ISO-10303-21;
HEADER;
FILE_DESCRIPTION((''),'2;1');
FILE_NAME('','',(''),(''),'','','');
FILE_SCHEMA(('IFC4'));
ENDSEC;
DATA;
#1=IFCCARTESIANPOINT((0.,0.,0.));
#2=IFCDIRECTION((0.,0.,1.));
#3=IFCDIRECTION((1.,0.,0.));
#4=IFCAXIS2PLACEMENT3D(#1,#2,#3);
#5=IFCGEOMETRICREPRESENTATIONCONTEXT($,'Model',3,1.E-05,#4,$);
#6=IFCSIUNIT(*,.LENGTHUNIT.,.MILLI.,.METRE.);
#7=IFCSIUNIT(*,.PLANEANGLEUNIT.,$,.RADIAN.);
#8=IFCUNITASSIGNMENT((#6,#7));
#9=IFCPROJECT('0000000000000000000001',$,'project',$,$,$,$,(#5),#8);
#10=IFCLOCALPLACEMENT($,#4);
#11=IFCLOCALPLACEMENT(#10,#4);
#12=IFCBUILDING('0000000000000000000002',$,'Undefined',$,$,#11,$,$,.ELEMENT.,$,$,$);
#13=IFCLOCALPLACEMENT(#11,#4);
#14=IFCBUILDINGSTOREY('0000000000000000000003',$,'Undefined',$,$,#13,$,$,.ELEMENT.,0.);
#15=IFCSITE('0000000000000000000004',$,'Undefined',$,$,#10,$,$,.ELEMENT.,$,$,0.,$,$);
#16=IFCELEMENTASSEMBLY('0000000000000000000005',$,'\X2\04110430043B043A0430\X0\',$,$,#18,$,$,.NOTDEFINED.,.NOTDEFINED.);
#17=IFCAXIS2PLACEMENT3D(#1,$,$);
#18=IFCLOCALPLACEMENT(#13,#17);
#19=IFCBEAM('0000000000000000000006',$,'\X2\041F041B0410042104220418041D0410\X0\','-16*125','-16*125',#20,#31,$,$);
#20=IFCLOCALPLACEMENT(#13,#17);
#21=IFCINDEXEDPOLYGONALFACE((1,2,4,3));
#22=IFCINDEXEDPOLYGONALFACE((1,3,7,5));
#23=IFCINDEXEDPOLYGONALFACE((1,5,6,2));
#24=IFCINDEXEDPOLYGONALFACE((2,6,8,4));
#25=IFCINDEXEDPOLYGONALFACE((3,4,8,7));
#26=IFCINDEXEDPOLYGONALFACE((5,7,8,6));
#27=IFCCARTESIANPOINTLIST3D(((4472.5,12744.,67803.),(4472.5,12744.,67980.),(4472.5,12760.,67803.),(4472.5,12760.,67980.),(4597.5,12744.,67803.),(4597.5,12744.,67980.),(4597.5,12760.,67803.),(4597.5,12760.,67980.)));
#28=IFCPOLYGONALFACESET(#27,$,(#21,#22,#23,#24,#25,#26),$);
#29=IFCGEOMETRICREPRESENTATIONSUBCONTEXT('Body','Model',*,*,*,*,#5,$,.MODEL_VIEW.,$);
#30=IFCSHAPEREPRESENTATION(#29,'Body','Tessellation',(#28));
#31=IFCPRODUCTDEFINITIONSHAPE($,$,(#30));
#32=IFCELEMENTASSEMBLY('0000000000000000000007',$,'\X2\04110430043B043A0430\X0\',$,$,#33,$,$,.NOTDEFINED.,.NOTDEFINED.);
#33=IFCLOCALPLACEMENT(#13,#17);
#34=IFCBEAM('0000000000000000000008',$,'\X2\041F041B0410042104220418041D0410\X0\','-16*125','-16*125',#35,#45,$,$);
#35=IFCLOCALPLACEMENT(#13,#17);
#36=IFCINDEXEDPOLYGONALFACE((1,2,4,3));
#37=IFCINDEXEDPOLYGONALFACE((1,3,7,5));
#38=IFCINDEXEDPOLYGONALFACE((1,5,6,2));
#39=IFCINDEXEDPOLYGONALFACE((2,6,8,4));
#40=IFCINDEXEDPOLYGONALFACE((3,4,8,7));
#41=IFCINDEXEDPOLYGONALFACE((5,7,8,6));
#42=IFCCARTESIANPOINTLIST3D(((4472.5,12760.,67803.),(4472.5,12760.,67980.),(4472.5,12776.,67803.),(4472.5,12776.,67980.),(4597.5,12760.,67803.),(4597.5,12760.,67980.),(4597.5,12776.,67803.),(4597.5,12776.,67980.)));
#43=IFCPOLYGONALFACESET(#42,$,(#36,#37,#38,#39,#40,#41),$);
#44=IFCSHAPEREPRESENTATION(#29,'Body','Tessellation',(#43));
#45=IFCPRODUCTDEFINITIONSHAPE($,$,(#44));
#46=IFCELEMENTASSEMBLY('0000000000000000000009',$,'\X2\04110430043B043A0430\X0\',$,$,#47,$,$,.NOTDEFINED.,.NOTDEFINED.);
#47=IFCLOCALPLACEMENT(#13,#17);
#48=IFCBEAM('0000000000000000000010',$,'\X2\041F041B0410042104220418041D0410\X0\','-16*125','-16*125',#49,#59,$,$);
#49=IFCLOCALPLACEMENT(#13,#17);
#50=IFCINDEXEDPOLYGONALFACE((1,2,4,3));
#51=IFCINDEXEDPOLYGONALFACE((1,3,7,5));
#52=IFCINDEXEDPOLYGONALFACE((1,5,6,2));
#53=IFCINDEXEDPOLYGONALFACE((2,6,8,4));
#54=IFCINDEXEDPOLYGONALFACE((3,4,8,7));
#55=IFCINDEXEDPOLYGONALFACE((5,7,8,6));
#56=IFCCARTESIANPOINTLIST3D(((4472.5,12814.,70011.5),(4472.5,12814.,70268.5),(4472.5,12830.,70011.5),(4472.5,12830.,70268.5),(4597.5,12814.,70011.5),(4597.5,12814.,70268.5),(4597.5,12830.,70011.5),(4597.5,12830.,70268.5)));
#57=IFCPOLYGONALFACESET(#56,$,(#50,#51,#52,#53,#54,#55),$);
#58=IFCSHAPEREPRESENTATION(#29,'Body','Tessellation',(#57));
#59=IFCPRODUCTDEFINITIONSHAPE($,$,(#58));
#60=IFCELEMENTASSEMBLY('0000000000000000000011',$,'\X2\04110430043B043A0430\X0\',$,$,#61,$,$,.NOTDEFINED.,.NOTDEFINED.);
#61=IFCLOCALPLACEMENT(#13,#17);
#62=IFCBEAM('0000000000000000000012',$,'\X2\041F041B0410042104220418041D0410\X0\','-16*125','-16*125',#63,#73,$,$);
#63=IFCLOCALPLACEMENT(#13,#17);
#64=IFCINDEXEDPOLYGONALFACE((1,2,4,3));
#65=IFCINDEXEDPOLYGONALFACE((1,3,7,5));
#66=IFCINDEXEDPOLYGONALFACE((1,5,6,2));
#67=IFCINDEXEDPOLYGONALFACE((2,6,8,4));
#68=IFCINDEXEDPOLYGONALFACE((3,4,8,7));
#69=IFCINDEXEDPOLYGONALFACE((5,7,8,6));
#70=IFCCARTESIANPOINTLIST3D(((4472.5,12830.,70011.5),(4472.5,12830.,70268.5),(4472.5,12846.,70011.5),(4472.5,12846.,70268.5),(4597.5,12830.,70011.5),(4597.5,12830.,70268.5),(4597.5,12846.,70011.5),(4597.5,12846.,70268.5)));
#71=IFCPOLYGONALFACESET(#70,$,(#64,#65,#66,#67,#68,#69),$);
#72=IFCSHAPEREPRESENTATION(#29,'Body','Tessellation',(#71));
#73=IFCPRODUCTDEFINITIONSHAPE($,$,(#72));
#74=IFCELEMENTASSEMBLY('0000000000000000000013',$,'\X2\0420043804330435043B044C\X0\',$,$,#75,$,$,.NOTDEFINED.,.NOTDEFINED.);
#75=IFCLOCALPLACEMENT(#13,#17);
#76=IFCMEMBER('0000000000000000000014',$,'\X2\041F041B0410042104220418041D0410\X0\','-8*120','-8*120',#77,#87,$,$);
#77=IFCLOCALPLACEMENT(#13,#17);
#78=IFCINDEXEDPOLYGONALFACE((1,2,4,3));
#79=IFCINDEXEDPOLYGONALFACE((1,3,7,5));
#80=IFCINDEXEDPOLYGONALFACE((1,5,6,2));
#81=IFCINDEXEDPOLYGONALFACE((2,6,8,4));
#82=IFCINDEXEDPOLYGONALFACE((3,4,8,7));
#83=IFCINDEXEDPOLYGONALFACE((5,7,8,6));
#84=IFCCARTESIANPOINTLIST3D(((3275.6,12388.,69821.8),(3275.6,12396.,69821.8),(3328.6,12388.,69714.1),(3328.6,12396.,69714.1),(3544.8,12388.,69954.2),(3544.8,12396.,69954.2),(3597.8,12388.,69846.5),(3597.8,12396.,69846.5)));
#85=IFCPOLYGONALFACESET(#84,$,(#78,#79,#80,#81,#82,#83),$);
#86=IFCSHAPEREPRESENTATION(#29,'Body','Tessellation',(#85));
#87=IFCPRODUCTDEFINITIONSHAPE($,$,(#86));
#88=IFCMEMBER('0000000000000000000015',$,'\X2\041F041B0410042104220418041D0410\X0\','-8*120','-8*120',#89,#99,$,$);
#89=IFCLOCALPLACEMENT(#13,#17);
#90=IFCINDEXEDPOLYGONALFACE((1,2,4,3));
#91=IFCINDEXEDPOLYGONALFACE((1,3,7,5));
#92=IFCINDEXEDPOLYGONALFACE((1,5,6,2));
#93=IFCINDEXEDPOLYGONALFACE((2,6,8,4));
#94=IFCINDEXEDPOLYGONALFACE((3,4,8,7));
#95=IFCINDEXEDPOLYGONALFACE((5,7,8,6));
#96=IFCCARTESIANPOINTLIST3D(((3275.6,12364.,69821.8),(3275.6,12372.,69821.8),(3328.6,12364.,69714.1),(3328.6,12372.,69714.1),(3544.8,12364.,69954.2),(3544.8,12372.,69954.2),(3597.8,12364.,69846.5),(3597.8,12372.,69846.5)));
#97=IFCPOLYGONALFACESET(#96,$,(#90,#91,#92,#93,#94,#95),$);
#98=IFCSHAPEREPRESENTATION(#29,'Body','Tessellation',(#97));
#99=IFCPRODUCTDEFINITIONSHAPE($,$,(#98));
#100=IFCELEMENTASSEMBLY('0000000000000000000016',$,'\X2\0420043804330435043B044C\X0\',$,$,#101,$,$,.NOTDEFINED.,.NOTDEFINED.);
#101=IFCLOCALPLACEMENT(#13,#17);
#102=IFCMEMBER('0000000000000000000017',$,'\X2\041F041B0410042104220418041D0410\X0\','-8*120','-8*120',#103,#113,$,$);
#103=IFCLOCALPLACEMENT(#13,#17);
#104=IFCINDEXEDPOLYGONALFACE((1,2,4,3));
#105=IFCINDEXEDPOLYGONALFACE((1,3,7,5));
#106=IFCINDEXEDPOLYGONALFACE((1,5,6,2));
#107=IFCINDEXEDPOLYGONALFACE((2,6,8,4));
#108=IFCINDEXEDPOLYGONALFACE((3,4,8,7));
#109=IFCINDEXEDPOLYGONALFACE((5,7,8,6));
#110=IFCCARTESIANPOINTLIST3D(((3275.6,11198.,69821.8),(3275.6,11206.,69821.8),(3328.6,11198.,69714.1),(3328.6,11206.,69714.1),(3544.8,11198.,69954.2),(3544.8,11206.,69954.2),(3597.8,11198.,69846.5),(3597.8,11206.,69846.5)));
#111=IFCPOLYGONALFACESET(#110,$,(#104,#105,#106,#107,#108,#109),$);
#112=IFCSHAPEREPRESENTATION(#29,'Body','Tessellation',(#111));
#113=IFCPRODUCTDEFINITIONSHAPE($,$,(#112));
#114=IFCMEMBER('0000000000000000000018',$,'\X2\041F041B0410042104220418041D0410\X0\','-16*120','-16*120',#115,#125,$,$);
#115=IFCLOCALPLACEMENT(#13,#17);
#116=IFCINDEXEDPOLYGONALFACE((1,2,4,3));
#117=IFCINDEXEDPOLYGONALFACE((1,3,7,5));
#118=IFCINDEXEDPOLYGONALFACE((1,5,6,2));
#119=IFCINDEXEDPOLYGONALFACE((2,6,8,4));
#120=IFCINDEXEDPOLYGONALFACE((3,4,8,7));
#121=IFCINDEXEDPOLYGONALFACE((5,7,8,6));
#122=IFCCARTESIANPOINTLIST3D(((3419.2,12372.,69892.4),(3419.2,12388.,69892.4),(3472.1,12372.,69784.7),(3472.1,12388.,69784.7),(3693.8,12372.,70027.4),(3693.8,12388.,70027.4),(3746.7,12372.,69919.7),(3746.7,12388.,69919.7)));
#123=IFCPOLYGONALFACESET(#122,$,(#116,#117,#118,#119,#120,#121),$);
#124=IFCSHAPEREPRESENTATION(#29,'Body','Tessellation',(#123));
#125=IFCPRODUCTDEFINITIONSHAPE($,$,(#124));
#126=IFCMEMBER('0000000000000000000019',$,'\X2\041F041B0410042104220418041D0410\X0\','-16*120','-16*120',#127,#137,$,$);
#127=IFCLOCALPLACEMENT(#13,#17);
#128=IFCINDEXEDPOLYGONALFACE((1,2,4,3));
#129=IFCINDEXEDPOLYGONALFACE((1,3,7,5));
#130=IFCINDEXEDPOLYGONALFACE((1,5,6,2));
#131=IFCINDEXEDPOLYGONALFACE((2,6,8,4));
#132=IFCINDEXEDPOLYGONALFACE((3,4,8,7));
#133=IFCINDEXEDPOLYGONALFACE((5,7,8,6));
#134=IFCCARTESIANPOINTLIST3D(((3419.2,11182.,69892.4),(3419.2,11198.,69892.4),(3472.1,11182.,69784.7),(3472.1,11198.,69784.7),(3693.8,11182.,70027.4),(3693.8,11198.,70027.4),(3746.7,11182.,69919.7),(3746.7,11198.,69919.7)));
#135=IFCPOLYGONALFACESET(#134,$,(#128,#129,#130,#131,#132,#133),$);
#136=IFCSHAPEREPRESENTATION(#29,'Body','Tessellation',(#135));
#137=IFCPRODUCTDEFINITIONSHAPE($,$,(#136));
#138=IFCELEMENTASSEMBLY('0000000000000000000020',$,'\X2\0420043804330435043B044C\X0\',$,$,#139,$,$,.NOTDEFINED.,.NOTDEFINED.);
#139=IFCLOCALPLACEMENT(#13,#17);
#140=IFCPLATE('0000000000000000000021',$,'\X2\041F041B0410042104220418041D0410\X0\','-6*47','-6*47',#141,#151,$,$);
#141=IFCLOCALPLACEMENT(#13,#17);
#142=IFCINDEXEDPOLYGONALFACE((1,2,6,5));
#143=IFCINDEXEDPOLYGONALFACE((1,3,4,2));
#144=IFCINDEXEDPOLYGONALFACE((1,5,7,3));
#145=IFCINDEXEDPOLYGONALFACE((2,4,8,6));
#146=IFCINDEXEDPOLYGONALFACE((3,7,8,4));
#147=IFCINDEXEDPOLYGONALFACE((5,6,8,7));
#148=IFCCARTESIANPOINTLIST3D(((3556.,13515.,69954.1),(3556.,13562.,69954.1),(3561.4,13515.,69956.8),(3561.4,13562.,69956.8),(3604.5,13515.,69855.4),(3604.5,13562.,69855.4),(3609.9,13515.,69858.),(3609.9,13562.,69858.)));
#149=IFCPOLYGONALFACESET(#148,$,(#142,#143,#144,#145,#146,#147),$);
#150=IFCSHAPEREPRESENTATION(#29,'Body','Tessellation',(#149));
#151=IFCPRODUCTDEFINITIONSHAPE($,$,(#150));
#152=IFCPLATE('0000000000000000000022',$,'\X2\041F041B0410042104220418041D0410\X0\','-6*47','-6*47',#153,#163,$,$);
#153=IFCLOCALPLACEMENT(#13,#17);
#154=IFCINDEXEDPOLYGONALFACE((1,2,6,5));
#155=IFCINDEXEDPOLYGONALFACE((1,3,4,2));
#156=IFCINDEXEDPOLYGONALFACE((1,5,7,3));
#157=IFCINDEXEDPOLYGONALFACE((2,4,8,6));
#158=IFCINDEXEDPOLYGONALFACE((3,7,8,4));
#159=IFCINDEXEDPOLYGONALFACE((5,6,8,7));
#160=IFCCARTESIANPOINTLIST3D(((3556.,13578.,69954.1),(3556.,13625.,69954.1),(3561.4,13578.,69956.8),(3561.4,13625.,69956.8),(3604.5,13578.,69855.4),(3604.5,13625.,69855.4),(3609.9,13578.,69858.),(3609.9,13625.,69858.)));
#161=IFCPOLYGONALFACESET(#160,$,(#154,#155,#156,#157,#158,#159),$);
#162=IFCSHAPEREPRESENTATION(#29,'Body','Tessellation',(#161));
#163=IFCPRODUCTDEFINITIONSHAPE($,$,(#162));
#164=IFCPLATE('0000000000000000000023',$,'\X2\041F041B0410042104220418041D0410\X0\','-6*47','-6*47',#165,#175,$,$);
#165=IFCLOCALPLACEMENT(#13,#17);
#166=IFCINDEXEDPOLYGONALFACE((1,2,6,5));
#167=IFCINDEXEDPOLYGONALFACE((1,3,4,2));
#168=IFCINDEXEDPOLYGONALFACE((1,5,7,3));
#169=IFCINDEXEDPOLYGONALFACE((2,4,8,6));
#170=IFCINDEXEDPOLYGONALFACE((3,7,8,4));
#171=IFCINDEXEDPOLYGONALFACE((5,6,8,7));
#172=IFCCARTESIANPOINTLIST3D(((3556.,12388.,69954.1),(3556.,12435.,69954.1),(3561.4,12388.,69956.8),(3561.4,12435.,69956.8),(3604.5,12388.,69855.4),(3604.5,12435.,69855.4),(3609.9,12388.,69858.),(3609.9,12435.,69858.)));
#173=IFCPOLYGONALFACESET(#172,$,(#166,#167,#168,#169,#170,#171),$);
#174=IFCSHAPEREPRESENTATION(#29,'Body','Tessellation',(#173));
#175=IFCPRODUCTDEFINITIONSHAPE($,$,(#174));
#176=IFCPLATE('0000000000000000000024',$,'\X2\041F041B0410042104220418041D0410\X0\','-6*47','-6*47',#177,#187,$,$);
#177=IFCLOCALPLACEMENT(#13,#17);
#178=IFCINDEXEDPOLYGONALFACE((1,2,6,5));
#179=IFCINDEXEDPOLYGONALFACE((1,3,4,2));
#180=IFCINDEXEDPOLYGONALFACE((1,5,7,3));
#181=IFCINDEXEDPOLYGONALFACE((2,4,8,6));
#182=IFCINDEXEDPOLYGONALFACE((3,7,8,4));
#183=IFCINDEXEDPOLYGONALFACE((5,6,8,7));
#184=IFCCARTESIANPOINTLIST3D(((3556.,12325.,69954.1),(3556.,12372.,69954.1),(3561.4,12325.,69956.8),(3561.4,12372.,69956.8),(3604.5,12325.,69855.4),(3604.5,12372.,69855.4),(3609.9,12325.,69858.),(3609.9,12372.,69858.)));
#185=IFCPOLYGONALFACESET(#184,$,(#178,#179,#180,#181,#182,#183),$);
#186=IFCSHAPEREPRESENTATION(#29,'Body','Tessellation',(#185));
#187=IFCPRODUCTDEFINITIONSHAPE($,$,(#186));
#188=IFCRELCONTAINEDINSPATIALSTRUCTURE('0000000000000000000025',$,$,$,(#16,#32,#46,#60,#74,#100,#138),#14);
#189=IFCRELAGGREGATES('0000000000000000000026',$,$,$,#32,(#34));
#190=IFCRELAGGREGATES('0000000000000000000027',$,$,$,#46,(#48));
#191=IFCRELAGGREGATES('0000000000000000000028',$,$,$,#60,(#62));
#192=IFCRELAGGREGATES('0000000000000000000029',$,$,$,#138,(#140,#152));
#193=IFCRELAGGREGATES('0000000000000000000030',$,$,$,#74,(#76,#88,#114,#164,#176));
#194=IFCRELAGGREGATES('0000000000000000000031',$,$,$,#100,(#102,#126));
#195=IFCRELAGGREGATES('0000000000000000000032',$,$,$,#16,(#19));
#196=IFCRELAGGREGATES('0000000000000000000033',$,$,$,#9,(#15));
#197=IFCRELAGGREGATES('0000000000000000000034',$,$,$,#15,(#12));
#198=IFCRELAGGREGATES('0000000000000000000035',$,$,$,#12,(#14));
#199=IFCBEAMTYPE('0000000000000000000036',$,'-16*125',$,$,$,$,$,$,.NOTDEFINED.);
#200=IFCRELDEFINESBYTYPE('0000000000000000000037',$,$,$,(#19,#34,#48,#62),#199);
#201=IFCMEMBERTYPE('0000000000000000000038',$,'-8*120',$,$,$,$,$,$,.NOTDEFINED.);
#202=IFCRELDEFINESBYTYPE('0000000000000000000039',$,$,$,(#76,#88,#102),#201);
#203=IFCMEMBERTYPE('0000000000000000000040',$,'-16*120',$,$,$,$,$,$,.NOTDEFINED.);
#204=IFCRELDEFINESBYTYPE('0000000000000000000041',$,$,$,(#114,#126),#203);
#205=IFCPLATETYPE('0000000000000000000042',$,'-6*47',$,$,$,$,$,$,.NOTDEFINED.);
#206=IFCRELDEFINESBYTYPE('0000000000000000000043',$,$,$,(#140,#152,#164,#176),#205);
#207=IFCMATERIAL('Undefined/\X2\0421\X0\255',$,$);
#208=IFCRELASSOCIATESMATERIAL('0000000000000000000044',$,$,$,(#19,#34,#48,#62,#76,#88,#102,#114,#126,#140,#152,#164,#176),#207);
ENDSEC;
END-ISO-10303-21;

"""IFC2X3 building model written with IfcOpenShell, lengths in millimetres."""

from ifc_helpers import new_model, si_unit, frame, origin_with_axes, origin_2d_with_axis, place, context, subcontext, project, spatial, polyline, rectangle, outline, extrude, boolean, material, type_object, element, aggregate, save


model = new_model("IFC2X3")

# Units and contexts
model_context = context("Model", 3, precision=1e-05, world=origin_with_axes())
body_context = subcontext(model_context, "Body", "Model", "MODEL_VIEW")
ifc_project = project(units=[si_unit("LENGTHUNIT", "METRE", prefix="MILLI"), si_unit("PLANEANGLEUNIT", "RADIAN")], contexts=[model_context])

# Site, building, storey
site_placement = place(None, origin_with_axes())
site = spatial("IfcSite", under=ifc_project, at=site_placement, Name="Undefined", CompositionType="ELEMENT", RefElevation=0.0)
building_placement = place(site_placement, origin_with_axes())
building = spatial("IfcBuilding", under=site, at=building_placement, Name="Undefined", CompositionType="ELEMENT")
storey_placement = place(building_placement, origin_with_axes())
storey = spatial("IfcBuildingStorey", under=building, at=storey_placement, Name="Undefined", CompositionType="ELEMENT", Elevation=0.0)

# Element assemblies, beams
assembly_1_placement = place(storey_placement, origin_with_axes())
assembly_1 = element("IfcElementAssembly", 1, at=assembly_1_placement, inside=storey, Name="Балка", AssemblyPlace="NOTDEFINED", PredefinedType="NOTDEFINED")
ifc_material_1 = material(Name="Undefined/С255")
beam_type = type_object("IfcBeamType", Name="-16*125", PredefinedType="NOTDEFINED")
beam_1_placement = place(assembly_1_placement, frame((4535.0, 12752.0, 67803.0), z_axis=(-1.0, 0.0, 0.0), x_axis=(0.0, 0.0, 1.0)))
beam_1 = element("IfcBeam", 2, at=beam_1_placement, type_object=beam_type, material=ifc_material_1, Name="ПЛАСТИНА", Description="-16*125", ObjectType="-16*125", context=body_context, shape_type="SweptSolid", body=[
    extrude(rectangle(XDim=16.0, YDim=125.0, at=origin_2d_with_axis()), frame((177.0, 0.0, 0.0), z_axis=(-1.0, 0.0, 0.0), x_axis=(0.0, -1.0, 0.0)), (0.0, 0.0, 1.0), 177.0),
])
assembly_2_placement = place(storey_placement, origin_with_axes())
assembly_2 = element("IfcElementAssembly", 3, at=assembly_2_placement, inside=storey, Name="Балка", AssemblyPlace="NOTDEFINED", PredefinedType="NOTDEFINED")
beam_2_placement = place(assembly_2_placement, frame((4535.0, 12768.0, 67803.0), z_axis=(-1.0, 0.0, 0.0), x_axis=(0.0, 0.0, 1.0)))
beam_2 = element("IfcBeam", 4, at=beam_2_placement, type_object=beam_type, material=ifc_material_1, Name="ПЛАСТИНА", Description="-16*125", ObjectType="-16*125", context=body_context, shape_type="SweptSolid", body=[
    extrude(rectangle(XDim=16.0, YDim=125.0, at=origin_2d_with_axis()), frame((177.0, 0.0, 0.0), z_axis=(-1.0, 0.0, 0.0), x_axis=(0.0, -1.0, 0.0)), (0.0, 0.0, 1.0), 177.0),
])
aggregate(assembly_2, [beam_2])
assembly_3_placement = place(storey_placement, origin_with_axes())
assembly_3 = element("IfcElementAssembly", 5, at=assembly_3_placement, inside=storey, Name="Балка", AssemblyPlace="NOTDEFINED", PredefinedType="NOTDEFINED")
beam_3_placement = place(assembly_3_placement, frame((4535.0, 12822.0, 70011.5), z_axis=(-1.0, 0.0, 0.0), x_axis=(0.0, 0.0, 1.0)))
beam_3 = element("IfcBeam", 6, at=beam_3_placement, type_object=beam_type, material=ifc_material_1, Name="ПЛАСТИНА", Description="-16*125", ObjectType="-16*125", context=body_context, shape_type="SweptSolid", body=[
    extrude(rectangle(XDim=16.0, YDim=125.0, at=origin_2d_with_axis()), frame((257.0, 0.0, 0.0), z_axis=(-1.0, 0.0, 0.0), x_axis=(0.0, -1.0, 0.0)), (0.0, 0.0, 1.0), 257.0),
])
aggregate(assembly_3, [beam_3])
assembly_4_placement = place(storey_placement, origin_with_axes())
assembly_4 = element("IfcElementAssembly", 7, at=assembly_4_placement, inside=storey, Name="Балка", AssemblyPlace="NOTDEFINED", PredefinedType="NOTDEFINED")
beam_4_placement = place(assembly_4_placement, frame((4535.0, 12838.0, 70011.5), z_axis=(-1.0, 0.0, 0.0), x_axis=(0.0, 0.0, 1.0)))
beam_4 = element("IfcBeam", 8, at=beam_4_placement, type_object=beam_type, material=ifc_material_1, Name="ПЛАСТИНА", Description="-16*125", ObjectType="-16*125", context=body_context, shape_type="SweptSolid", body=[
    extrude(rectangle(XDim=16.0, YDim=125.0, at=origin_2d_with_axis()), frame((257.0, 0.0, 0.0), z_axis=(-1.0, 0.0, 0.0), x_axis=(0.0, -1.0, 0.0)), (0.0, 0.0, 1.0), 257.0),
])
aggregate(assembly_4, [beam_4])

# Element assembly, members
assembly_5_placement = place(storey_placement, origin_with_axes())
assembly_5 = element("IfcElementAssembly", 9, at=assembly_5_placement, inside=storey, Name="Ригель", AssemblyPlace="NOTDEFINED", PredefinedType="NOTDEFINED")
member_type_1 = type_object("IfcMemberType", Name="-8*120", PredefinedType="NOTDEFINED")
member_1_placement = place(assembly_5_placement, frame((3302.1, 12392.0, 69768.0), z_axis=(0.441221, 0.0, -0.897399), x_axis=(0.897399, 0.0, 0.441221)))
member_1 = element("IfcMember", 10, at=member_1_placement, type_object=member_type_1, material=ifc_material_1, Name="ПЛАСТИНА", Description="-8*120", ObjectType="-8*120", context=body_context, shape_type="SweptSolid", body=[
    extrude(rectangle(XDim=8.0, YDim=120.0, at=origin_2d_with_axis()), frame((300.0, 0.0, 0.0), z_axis=(-1.0, 0.0, 0.0), x_axis=(0.0, -1.0, 0.0)), (0.0, 0.0, 1.0), 300.0),
])
member_2_placement = place(assembly_5_placement, frame((3302.1, 12368.0, 69768.0), z_axis=(0.441221, 0.0, -0.897399), x_axis=(0.897399, 0.0, 0.441221)))
member_2 = element("IfcMember", 11, at=member_2_placement, type_object=member_type_1, material=ifc_material_1, Name="ПЛАСТИНА", Description="-8*120", ObjectType="-8*120", context=body_context, shape_type="SweptSolid", body=[
    extrude(rectangle(XDim=8.0, YDim=120.0, at=origin_2d_with_axis()), frame((300.0, 0.0, 0.0), z_axis=(-1.0, 0.0, 0.0), x_axis=(0.0, -1.0, 0.0)), (0.0, 0.0, 1.0), 300.0),
])

# Element assembly, member
assembly_6_placement = place(storey_placement, origin_with_axes())
assembly_6 = element("IfcElementAssembly", 12, at=assembly_6_placement, inside=storey, Name="Ригель", AssemblyPlace="NOTDEFINED", PredefinedType="NOTDEFINED")
member_3_placement = place(assembly_6_placement, frame((3302.1, 11202.0, 69768.0), z_axis=(0.441221, 0.0, -0.897399), x_axis=(0.897399, 0.0, 0.441221)))
member_3 = element("IfcMember", 13, at=member_3_placement, type_object=member_type_1, material=ifc_material_1, Name="ПЛАСТИНА", Description="-8*120", ObjectType="-8*120", context=body_context, shape_type="SweptSolid", body=[
    extrude(rectangle(XDim=8.0, YDim=120.0, at=origin_2d_with_axis()), frame((300.0, 0.0, 0.0), z_axis=(-1.0, 0.0, 0.0), x_axis=(0.0, -1.0, 0.0)), (0.0, 0.0, 1.0), 300.0),
])

# Members
member_type_2 = type_object("IfcMemberType", Name="-16*120", PredefinedType="NOTDEFINED")
member_4_placement = place(assembly_5_placement, frame((3445.7, 12380.0, 69838.6), z_axis=(0.441221, 0.0, -0.897399), x_axis=(0.897399, 0.0, 0.441221)))
member_4 = element("IfcMember", 14, at=member_4_placement, type_object=member_type_2, material=ifc_material_1, Name="ПЛАСТИНА", Description="-16*120", ObjectType="-16*120", context=body_context, shape_type="SweptSolid", body=[
    extrude(rectangle(XDim=16.0, YDim=120.0, at=origin_2d_with_axis()), frame((306.0, 0.0, 0.0), z_axis=(-1.0, 0.0, 0.0), x_axis=(0.0, -1.0, 0.0)), (0.0, 0.0, 1.0), 306.0),
])
member_5_placement = place(assembly_6_placement, frame((3445.7, 11190.0, 69838.6), z_axis=(0.441221, 0.0, -0.897399), x_axis=(0.897399, 0.0, 0.441221)))
member_5 = element("IfcMember", 15, at=member_5_placement, type_object=member_type_2, material=ifc_material_1, Name="ПЛАСТИНА", Description="-16*120", ObjectType="-16*120", context=body_context, shape_type="SweptSolid", body=[
    extrude(rectangle(XDim=16.0, YDim=120.0, at=origin_2d_with_axis()), frame((306.0, 0.0, 0.0), z_axis=(-1.0, 0.0, 0.0), x_axis=(0.0, -1.0, 0.0)), (0.0, 0.0, 1.0), 306.0),
])

# Element assembly, plates
assembly_7_placement = place(storey_placement, origin_with_axes())
assembly_7 = element("IfcElementAssembly", 16, at=assembly_7_placement, inside=storey, Name="Ригель", AssemblyPlace="NOTDEFINED", PredefinedType="NOTDEFINED")
plate_type_1 = type_object("IfcPlateType", Name="-6*47", PredefinedType="NOTDEFINED")
plate_1_placement = place(assembly_7_placement, frame((3607.2, 13515.0, 69856.7), z_axis=(-0.897399, 0.0, -0.441221), x_axis=(-0.441221, 0.0, 0.897399)))
plate_1 = element("IfcPlate", 17, at=plate_1_placement, type_object=plate_type_1, material=ifc_material_1, Name="ПЛАСТИНА", Description="-6*47", ObjectType="-6*47", context=body_context, shape_type="CSG", body=[
    boolean("DIFFERENCE", extrude(outline(polyline([(0.0, 0.0), (110.0, 0.0), (110.0, 110.0), (0.0, 110.0), (0.0, 0.0)])), frame((0.0, 0.0, -3.0), z_axis=(0.0, 0.0, 1.0), x_axis=(1.0, 0.0, 0.0)), (0.0, 0.0, 1.0), 6.0), extrude(rectangle(XDim=26.0, YDim=130.0, at=origin_2d_with_axis()), frame((55.0, 47.0, 0.0), z_axis=(0.0, 1.0, 0.0), x_axis=(0.0, 0.0, -1.0)), (0.0, 0.0, 1.0), 66.0)),
])
plate_2_placement = place(assembly_7_placement, frame((3607.2, 13515.0, 69856.7), z_axis=(-0.897399, 0.0, -0.441221), x_axis=(-0.441221, 0.0, 0.897399)))
plate_2 = element("IfcPlate", 18, at=plate_2_placement, type_object=plate_type_1, material=ifc_material_1, Name="ПЛАСТИНА", Description="-6*47", ObjectType="-6*47", context=body_context, shape_type="CSG", body=[
    boolean("DIFFERENCE", extrude(outline(polyline([(0.0, 0.0), (110.0, 0.0), (110.0, 110.0), (0.0, 110.0), (0.0, 0.0)])), frame((0.0, 0.0, -3.0), z_axis=(0.0, 0.0, 1.0), x_axis=(1.0, 0.0, 0.0)), (0.0, 0.0, 1.0), 6.0), extrude(rectangle(XDim=26.0, YDim=130.0, at=origin_2d_with_axis()), frame((55.0, -3.0, 0.0), z_axis=(0.0, 1.0, 0.0), x_axis=(0.0, 0.0, -1.0)), (0.0, 0.0, 1.0), 66.0)),
])
aggregate(assembly_7, [plate_1, plate_2])

# Plates
plate_3_placement = place(assembly_5_placement, frame((3607.2, 12325.0, 69856.7), z_axis=(-0.897399, 0.0, -0.441221), x_axis=(-0.441221, 0.0, 0.897399)))
plate_3 = element("IfcPlate", 19, at=plate_3_placement, type_object=plate_type_1, material=ifc_material_1, Name="ПЛАСТИНА", Description="-6*47", ObjectType="-6*47", context=body_context, shape_type="CSG", body=[
    boolean("DIFFERENCE", extrude(outline(polyline([(0.0, 0.0), (110.0, 0.0), (110.0, 110.0), (0.0, 110.0), (0.0, 0.0)])), frame((0.0, 0.0, -3.0), z_axis=(0.0, 0.0, 1.0), x_axis=(1.0, 0.0, 0.0)), (0.0, 0.0, 1.0), 6.0), extrude(rectangle(XDim=26.0, YDim=130.0, at=origin_2d_with_axis()), frame((55.0, -3.0, 0.0), z_axis=(0.0, 1.0, 0.0), x_axis=(0.0, 0.0, -1.0)), (0.0, 0.0, 1.0), 66.0)),
])
plate_4_placement = place(assembly_5_placement, frame((3607.2, 12325.0, 69856.7), z_axis=(-0.897399, 0.0, -0.441221), x_axis=(-0.441221, 0.0, 0.897399)))
plate_4 = element("IfcPlate", 20, at=plate_4_placement, type_object=plate_type_1, material=ifc_material_1, Name="ПЛАСТИНА", Description="-6*47", ObjectType="-6*47", context=body_context, shape_type="CSG", body=[
    boolean("DIFFERENCE", extrude(outline(polyline([(0.0, 0.0), (110.0, 0.0), (110.0, 110.0), (0.0, 110.0), (0.0, 0.0)])), frame((0.0, 0.0, -3.0), z_axis=(0.0, 0.0, 1.0), x_axis=(1.0, 0.0, 0.0)), (0.0, 0.0, 1.0), 6.0), extrude(rectangle(XDim=26.0, YDim=130.0, at=origin_2d_with_axis()), frame((55.0, 47.0, 0.0), z_axis=(0.0, 1.0, 0.0), x_axis=(0.0, 0.0, -1.0)), (0.0, 0.0, 1.0), 66.0)),
])

aggregate(assembly_5, [member_1, member_2, member_4, plate_3, plate_4])
aggregate(assembly_6, [member_3, member_5])

aggregate(assembly_1, [beam_1])

save(model, "model.ifc")
